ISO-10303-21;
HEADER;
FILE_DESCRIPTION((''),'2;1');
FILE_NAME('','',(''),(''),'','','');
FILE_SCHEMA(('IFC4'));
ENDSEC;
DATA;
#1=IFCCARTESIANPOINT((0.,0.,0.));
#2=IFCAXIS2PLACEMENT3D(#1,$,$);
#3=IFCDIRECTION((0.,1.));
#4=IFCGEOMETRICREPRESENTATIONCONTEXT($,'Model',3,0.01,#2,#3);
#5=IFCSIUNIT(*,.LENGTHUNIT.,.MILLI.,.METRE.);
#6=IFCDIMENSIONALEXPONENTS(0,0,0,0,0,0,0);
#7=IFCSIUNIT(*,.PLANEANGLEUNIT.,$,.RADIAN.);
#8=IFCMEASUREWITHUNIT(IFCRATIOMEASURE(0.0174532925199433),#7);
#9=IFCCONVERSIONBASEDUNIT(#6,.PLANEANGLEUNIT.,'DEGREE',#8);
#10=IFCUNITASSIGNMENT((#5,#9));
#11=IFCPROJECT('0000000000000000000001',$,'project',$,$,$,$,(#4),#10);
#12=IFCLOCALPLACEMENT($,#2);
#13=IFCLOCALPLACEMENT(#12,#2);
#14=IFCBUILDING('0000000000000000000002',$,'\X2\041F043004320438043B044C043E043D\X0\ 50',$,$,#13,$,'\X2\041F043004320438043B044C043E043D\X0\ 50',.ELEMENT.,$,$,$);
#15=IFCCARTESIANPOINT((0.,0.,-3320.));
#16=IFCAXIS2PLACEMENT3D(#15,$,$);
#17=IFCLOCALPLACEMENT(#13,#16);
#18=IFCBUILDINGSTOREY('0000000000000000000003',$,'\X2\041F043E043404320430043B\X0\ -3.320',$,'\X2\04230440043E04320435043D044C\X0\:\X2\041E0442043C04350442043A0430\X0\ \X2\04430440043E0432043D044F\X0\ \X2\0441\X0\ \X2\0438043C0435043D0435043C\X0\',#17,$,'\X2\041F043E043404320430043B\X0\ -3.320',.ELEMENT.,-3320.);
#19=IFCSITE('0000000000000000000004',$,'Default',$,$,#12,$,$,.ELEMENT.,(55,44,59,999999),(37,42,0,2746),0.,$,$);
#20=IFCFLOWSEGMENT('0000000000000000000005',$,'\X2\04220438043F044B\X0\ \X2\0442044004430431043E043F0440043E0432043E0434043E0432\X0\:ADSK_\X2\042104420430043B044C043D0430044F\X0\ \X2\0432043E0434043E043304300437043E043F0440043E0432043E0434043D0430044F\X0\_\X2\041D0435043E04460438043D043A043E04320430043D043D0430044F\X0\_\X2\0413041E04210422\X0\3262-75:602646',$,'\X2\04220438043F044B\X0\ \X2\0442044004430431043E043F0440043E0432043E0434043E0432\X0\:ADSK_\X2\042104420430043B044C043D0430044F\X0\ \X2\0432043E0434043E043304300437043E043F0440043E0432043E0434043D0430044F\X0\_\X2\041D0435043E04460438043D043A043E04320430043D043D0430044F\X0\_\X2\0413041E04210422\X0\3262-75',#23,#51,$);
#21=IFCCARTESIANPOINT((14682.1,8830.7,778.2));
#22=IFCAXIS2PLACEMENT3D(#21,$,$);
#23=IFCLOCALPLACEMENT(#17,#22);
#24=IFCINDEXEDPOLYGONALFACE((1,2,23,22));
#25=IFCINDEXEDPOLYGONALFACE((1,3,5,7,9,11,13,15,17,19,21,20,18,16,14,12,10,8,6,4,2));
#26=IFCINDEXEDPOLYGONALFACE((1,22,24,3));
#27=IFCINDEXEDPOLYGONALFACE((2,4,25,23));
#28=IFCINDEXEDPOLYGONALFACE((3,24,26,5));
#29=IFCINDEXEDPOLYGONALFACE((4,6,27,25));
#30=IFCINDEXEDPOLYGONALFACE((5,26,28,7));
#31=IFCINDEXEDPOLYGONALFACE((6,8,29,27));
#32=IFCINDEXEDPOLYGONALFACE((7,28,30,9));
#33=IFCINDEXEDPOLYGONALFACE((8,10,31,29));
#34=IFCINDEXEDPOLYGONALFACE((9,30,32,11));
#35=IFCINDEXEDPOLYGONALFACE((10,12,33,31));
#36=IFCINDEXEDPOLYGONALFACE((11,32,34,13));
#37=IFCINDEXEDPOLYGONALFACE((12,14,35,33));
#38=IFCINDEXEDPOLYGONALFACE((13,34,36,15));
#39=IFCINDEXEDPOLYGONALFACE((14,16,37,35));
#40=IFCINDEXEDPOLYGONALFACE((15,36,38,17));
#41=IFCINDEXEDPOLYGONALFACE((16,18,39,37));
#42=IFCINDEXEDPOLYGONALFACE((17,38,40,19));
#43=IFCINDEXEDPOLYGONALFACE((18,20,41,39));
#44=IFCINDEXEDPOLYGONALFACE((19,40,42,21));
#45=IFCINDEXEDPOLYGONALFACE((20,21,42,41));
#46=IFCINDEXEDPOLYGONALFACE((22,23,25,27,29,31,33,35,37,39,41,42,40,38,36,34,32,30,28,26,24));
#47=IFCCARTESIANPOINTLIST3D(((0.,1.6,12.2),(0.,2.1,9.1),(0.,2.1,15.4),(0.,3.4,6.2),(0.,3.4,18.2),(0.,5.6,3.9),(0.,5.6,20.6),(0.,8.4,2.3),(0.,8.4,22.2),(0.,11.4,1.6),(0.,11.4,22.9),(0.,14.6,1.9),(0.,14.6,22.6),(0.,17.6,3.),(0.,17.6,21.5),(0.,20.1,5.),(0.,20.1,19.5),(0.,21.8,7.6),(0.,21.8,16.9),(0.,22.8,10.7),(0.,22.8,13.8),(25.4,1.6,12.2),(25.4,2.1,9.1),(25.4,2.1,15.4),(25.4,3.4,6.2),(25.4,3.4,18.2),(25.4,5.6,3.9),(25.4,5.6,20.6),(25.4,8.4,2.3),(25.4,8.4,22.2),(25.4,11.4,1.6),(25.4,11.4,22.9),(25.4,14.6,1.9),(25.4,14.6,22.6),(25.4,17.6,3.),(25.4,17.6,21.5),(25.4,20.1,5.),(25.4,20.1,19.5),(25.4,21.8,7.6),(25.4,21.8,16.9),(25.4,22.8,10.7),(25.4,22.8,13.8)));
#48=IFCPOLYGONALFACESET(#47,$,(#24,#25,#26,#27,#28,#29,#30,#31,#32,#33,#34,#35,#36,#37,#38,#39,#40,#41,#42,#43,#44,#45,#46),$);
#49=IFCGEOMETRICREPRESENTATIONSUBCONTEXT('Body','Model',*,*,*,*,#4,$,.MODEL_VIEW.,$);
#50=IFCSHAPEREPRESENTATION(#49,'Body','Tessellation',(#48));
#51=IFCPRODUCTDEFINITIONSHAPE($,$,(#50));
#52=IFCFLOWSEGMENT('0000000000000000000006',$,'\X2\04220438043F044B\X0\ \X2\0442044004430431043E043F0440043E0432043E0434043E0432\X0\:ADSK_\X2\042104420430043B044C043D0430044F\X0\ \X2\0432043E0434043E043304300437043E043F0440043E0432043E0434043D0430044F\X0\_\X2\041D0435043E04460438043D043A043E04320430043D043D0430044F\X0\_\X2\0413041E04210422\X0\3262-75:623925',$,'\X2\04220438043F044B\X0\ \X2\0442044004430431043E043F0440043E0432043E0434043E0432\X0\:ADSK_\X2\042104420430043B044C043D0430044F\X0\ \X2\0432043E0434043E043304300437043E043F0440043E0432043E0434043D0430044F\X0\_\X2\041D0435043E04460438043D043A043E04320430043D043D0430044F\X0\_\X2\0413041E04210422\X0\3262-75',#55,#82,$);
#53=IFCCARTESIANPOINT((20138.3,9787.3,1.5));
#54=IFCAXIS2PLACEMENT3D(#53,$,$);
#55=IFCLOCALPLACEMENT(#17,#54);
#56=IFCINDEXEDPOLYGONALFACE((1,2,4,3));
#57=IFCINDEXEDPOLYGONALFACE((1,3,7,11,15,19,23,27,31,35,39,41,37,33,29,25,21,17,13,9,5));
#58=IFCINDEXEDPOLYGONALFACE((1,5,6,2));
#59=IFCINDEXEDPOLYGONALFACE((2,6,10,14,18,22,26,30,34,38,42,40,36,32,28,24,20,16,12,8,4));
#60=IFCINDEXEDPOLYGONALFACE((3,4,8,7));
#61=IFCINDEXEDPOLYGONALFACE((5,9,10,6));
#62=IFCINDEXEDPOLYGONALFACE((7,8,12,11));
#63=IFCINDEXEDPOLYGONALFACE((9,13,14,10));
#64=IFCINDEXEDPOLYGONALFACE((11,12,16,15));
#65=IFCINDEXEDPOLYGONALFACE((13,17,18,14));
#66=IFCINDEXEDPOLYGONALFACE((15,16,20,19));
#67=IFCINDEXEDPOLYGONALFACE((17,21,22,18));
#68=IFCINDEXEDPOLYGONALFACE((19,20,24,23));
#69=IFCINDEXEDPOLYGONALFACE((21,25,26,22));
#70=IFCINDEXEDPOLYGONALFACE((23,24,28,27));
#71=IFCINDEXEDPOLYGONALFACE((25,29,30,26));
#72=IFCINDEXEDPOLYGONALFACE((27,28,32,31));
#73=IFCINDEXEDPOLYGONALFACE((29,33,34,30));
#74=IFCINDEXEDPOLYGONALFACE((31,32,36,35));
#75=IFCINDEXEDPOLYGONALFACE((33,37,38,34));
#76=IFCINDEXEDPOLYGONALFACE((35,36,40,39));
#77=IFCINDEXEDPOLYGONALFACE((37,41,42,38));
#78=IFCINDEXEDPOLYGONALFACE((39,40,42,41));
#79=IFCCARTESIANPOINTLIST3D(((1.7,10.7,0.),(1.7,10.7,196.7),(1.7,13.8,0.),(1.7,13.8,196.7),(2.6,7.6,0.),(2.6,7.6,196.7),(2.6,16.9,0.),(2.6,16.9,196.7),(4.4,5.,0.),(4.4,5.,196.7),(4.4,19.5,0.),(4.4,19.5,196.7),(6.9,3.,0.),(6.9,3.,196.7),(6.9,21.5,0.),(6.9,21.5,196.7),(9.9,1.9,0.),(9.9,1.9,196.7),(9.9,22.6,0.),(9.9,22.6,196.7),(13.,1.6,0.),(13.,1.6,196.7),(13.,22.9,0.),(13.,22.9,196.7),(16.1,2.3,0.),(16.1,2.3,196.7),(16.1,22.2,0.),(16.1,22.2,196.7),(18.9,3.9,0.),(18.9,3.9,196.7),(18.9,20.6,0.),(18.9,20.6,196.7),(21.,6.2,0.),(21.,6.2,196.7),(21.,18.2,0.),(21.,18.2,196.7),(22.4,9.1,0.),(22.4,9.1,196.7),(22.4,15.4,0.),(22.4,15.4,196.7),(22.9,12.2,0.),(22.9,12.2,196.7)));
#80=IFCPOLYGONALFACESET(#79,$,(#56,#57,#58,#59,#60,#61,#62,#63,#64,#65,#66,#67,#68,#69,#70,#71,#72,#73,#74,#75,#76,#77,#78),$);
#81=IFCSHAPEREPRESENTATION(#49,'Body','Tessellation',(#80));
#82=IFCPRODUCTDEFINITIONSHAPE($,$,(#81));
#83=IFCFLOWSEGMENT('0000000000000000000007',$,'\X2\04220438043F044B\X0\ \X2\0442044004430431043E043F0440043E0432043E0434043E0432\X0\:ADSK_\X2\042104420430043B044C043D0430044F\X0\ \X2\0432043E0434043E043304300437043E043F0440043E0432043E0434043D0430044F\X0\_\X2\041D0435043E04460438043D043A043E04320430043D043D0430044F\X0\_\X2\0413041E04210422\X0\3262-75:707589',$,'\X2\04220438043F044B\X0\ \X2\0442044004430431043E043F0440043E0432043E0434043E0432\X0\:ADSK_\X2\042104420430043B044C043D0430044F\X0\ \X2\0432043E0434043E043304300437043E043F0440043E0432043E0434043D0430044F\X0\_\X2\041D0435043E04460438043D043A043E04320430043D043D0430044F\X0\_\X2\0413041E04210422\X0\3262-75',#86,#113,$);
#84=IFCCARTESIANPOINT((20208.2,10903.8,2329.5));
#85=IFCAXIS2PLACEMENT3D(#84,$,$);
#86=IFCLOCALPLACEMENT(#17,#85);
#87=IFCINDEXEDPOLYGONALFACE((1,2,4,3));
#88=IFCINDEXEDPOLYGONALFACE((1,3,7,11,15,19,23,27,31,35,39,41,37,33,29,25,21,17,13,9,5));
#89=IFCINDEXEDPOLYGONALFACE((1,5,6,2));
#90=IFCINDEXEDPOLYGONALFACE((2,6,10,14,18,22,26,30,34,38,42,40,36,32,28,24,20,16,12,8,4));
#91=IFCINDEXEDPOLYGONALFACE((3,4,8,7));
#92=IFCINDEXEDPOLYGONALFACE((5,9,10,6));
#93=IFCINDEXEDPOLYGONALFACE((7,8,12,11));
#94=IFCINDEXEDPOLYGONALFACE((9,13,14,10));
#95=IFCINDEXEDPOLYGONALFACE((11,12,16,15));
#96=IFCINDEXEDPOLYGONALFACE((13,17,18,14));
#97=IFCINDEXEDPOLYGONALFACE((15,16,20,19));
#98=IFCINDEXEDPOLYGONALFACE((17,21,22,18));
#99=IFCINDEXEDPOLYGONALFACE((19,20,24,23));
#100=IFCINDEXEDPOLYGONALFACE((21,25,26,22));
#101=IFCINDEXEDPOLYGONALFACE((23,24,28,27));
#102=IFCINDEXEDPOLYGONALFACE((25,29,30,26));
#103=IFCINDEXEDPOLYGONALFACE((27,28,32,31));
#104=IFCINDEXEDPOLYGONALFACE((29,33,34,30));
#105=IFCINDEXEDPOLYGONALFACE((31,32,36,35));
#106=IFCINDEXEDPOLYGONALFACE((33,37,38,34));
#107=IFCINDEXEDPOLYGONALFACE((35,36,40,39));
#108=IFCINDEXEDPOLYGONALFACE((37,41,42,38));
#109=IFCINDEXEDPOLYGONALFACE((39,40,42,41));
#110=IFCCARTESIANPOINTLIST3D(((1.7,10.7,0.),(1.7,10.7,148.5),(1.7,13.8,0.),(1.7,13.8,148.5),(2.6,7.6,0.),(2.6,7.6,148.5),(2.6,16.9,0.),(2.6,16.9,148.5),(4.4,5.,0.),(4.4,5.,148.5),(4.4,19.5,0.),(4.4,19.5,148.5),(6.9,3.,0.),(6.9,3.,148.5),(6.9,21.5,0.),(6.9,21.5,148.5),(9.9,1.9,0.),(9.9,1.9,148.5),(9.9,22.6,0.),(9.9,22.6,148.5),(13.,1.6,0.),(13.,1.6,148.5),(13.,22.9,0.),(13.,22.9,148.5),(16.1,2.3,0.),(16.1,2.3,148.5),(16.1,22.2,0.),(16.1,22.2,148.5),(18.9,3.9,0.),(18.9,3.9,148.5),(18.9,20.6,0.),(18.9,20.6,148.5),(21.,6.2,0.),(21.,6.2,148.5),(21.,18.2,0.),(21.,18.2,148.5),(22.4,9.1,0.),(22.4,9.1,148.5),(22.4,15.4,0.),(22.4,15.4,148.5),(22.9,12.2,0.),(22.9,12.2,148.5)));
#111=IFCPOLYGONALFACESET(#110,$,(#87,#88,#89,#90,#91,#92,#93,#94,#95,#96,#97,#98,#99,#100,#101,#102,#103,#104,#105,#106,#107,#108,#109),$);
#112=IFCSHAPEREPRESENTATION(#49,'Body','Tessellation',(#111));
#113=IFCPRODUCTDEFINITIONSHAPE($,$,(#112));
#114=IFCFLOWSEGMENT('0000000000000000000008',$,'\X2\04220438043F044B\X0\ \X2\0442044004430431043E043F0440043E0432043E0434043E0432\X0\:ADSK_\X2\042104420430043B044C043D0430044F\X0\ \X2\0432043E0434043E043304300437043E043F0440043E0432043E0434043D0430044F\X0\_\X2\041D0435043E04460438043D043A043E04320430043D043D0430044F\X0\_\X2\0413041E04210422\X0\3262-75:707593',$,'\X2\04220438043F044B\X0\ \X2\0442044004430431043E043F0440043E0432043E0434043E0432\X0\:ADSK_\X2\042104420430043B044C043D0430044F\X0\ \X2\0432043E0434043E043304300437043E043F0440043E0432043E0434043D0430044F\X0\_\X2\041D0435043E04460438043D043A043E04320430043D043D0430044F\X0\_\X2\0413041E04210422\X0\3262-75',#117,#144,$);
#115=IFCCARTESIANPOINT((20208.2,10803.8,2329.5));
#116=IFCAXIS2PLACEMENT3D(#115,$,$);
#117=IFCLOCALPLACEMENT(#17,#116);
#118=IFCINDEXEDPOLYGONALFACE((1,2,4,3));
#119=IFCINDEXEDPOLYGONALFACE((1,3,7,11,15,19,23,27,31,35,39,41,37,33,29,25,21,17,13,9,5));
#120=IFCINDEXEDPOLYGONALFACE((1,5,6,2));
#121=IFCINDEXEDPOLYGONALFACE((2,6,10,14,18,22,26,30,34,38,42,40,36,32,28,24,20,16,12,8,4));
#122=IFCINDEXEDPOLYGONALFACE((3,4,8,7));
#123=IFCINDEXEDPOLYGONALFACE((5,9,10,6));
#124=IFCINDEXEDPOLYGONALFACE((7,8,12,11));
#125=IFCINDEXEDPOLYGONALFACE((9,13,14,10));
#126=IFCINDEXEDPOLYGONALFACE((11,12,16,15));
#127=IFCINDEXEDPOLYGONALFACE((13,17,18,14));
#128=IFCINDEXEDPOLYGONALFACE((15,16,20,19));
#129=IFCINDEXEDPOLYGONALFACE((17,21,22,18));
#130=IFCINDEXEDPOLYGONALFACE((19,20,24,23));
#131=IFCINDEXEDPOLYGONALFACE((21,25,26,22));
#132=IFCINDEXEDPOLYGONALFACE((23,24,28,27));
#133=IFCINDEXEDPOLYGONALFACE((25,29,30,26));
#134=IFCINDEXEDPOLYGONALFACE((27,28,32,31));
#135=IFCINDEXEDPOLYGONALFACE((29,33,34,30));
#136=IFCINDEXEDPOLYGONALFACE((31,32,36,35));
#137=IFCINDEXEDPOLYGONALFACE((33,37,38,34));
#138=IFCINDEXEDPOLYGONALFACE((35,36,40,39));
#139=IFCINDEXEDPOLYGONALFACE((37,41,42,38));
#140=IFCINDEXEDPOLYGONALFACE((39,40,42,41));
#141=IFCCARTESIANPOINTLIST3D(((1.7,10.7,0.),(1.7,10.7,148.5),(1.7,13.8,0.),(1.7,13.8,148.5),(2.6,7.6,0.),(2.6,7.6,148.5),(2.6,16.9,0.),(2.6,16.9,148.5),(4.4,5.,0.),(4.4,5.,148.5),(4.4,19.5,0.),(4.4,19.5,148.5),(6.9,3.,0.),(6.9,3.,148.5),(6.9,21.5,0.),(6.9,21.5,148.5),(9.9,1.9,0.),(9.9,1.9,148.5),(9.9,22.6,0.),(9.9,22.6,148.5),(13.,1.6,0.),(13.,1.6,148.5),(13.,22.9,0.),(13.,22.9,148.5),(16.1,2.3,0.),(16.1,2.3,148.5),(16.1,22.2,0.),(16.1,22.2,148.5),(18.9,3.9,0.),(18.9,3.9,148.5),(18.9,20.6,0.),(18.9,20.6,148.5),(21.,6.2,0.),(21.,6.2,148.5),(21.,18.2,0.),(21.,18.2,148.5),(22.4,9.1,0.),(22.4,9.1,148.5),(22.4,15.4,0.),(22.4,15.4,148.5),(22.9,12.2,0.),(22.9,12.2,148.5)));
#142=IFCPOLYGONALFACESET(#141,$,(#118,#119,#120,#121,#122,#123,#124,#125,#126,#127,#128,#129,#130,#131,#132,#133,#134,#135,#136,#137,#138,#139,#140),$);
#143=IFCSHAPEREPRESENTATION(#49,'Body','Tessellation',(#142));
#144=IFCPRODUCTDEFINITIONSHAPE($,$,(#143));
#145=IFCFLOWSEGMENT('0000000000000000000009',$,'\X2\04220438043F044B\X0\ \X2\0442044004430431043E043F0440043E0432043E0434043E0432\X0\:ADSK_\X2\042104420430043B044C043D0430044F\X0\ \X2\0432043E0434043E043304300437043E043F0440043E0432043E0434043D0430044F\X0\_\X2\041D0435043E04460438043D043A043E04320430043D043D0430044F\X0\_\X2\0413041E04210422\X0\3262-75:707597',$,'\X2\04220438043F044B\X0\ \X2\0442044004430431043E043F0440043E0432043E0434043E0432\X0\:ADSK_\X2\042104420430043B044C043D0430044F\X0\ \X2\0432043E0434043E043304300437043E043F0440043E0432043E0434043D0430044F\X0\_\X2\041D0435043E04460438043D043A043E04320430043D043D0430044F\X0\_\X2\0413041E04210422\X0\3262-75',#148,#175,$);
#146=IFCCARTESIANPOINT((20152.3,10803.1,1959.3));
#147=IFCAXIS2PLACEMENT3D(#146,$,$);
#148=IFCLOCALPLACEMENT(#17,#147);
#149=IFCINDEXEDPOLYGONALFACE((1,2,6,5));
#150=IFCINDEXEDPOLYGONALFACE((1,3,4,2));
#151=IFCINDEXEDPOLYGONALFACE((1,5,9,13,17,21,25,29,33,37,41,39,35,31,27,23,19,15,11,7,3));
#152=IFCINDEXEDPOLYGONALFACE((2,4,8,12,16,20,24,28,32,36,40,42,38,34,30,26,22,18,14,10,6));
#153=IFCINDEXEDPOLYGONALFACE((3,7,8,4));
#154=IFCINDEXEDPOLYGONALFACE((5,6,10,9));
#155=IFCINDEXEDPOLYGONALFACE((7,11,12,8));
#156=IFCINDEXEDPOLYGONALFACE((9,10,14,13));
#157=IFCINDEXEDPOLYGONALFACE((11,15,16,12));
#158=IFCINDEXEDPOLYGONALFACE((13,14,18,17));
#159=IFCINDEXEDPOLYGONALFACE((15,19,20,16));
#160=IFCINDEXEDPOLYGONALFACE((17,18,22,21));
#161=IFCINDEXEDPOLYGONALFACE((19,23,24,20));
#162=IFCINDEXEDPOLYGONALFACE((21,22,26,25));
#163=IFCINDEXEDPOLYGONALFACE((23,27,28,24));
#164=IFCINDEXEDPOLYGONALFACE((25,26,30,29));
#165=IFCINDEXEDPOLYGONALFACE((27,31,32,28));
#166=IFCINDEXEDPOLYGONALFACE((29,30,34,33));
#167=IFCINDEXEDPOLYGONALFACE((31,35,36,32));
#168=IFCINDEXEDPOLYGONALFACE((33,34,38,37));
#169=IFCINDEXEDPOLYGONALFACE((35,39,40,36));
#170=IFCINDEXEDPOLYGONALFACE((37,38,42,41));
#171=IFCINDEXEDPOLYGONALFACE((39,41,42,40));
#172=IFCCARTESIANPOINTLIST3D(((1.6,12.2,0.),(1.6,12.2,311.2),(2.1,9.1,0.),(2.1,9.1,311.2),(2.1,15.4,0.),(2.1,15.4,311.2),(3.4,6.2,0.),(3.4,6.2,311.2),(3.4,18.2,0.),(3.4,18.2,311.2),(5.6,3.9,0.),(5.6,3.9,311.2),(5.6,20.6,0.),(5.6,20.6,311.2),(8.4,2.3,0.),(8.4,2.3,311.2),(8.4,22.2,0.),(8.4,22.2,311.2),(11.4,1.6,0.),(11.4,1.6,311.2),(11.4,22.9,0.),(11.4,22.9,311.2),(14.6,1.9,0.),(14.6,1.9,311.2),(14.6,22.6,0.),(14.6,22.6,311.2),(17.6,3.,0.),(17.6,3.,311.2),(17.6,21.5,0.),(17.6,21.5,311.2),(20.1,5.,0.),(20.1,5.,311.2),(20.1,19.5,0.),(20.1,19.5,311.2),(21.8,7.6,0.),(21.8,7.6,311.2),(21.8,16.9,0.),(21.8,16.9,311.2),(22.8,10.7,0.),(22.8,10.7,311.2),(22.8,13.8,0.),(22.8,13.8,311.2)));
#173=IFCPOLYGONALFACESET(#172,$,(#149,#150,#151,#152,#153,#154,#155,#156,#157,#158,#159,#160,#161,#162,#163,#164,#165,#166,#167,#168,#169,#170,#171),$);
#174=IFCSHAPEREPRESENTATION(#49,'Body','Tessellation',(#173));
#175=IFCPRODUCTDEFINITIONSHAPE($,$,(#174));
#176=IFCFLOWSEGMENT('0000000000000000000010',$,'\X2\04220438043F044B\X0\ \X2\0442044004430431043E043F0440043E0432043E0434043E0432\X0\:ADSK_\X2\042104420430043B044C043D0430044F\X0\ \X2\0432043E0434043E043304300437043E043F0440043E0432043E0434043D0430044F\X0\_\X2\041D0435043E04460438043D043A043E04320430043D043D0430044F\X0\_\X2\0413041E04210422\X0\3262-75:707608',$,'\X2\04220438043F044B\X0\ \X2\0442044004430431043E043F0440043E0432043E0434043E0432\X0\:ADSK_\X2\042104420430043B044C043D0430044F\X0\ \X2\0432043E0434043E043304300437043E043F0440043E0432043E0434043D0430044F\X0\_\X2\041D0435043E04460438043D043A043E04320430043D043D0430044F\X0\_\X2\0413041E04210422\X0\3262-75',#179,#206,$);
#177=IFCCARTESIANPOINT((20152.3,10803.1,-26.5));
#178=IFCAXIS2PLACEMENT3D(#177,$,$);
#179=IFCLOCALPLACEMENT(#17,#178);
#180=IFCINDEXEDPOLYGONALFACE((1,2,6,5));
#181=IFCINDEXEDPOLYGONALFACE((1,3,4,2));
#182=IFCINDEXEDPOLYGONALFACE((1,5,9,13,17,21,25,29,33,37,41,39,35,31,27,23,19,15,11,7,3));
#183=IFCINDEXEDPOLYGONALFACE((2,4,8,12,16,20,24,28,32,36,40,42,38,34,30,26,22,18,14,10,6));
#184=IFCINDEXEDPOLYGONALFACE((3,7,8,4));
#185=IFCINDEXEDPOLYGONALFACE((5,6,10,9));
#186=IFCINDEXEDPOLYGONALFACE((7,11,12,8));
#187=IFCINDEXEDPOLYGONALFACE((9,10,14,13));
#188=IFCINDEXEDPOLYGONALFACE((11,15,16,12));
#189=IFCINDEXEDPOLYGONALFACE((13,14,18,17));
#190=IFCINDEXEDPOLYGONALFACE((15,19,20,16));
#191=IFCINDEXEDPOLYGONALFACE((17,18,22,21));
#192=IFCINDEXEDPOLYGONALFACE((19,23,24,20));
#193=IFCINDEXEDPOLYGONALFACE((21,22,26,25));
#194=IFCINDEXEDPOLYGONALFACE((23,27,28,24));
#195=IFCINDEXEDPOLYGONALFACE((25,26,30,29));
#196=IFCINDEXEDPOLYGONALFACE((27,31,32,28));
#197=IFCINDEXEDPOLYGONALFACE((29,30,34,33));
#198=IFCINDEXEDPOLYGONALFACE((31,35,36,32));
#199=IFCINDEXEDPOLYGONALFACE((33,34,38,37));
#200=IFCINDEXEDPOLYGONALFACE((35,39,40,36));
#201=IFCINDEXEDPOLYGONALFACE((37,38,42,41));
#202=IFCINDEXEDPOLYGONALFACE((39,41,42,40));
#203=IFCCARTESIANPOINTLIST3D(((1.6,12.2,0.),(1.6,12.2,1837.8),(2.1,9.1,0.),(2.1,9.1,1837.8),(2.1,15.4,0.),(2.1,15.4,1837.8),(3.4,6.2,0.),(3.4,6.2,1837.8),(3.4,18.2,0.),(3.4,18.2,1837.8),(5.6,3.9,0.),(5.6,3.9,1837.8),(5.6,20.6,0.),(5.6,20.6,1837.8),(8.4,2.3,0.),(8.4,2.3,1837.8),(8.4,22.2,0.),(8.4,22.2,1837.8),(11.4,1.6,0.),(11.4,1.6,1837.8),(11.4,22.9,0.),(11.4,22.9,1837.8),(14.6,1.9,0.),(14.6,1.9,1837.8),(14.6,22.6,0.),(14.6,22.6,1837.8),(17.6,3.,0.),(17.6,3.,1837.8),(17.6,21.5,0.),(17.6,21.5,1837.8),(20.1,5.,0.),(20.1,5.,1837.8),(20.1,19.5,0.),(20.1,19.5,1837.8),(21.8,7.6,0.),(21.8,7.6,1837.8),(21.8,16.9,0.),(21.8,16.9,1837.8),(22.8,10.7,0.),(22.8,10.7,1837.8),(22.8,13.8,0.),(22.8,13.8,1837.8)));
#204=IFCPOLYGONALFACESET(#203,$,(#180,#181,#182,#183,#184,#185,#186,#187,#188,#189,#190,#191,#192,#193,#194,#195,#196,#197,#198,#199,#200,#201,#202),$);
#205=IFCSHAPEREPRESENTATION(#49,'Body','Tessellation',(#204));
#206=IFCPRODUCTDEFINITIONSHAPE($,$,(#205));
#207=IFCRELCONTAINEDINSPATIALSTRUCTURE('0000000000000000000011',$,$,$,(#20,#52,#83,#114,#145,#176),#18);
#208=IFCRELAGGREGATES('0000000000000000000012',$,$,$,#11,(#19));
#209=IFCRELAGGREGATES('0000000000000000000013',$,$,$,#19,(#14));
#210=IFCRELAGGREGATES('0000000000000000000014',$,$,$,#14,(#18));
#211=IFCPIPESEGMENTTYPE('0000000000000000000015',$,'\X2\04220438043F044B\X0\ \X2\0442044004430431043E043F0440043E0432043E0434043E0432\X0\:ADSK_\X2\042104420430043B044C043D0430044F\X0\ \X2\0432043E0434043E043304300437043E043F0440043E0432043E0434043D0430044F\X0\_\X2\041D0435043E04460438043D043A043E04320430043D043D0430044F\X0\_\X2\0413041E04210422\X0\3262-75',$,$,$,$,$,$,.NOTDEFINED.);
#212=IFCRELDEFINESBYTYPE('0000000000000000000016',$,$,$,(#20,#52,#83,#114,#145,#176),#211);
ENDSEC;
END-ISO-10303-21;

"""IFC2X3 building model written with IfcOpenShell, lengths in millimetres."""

from ifc_helpers import new_model, entity, si_unit, converted_unit, direction, frame, frame_2d, origin, origin_2d_with_axis, place, context, subcontext, project, spatial, circle, extrude, type_object, element, save


model = new_model("IFC2X3")

# Units and contexts
model_context = context("Model", 3, precision=0.01, world=origin(), true_north=direction((0.0, 1.0)))
body_context = subcontext(model_context, "Body", "Model", "MODEL_VIEW")
ifc_project = project(units=[si_unit("LENGTHUNIT", "METRE", prefix="MILLI"), converted_unit("PLANEANGLEUNIT", "DEGREE", entity("IfcRatioMeasure", 0.0174532925199433), si_unit("PLANEANGLEUNIT", "RADIAN"), dimensions=[0, 0, 0, 0, 0, 0, 0])], contexts=[model_context])

# Site, building, storey
site_placement = place(None, origin())
site = spatial("IfcSite", under=ifc_project, at=site_placement, Name="Default", CompositionType="ELEMENT", RefLatitude=(55, 44, 59, 999999), RefLongitude=(37, 42, 0, 2746), RefElevation=0.0)
building_placement = place(site_placement, origin())
building = spatial("IfcBuilding", under=site, at=building_placement, Name="Павильон 50", LongName="Павильон 50", CompositionType="ELEMENT")
storey_placement = place(building_placement, frame((0.0, 0.0, -3320.0)))
storey = spatial("IfcBuildingStorey", under=building, at=storey_placement, Name="Подвал -3.320", ObjectType="Уровень:Отметка уровня с именем", LongName="Подвал -3.320", CompositionType="ELEMENT", Elevation=-3320.0)

# Flow segments
pipe_segment_type = type_object("IfcPipeSegmentType", Name="Типы трубопроводов:ADSK_Стальная водогазопроводная_Неоцинкованная_ГОСТ3262-75", PredefinedType="NOTDEFINED")
flow_segment_1_placement = place(storey_placement, frame((14682.1, 8830.7, 778.2)))
element("IfcFlowSegment", 1, at=flow_segment_1_placement, inside=storey, type_object=pipe_segment_type, Name="Типы трубопроводов:ADSK_Стальная водогазопроводная_Неоцинкованная_ГОСТ3262-75:602646", ObjectType="Типы трубопроводов:ADSK_Стальная водогазопроводная_Неоцинкованная_ГОСТ3262-75", context=body_context, shape_type="SweptSolid", body=[
    extrude(circle(Radius=10.7, at=origin_2d_with_axis()), frame((0.0, 12.2, 12.2), z_axis=(1.0, 0.0, 0.0), x_axis=(0.0, -1.0, 0.0)), (0.0, 0.0, 1.0), 25.4),
])
flow_segment_2_placement = place(storey_placement, frame((20138.3, 9787.3, 1.5)))
element("IfcFlowSegment", 2, at=flow_segment_2_placement, inside=storey, type_object=pipe_segment_type, Name="Типы трубопроводов:ADSK_Стальная водогазопроводная_Неоцинкованная_ГОСТ3262-75:623925", ObjectType="Типы трубопроводов:ADSK_Стальная водогазопроводная_Неоцинкованная_ГОСТ3262-75", context=body_context, shape_type="SweptSolid", body=[
    extrude(circle(Radius=10.7, at=origin_2d_with_axis()), frame((12.2, 12.2, 0.0)), (0.0, 0.0, 1.0), 196.7),
])
flow_segment_3_placement = place(storey_placement, frame((20208.2, 10903.8, 2329.5)))
element("IfcFlowSegment", 3, at=flow_segment_3_placement, inside=storey, type_object=pipe_segment_type, Name="Типы трубопроводов:ADSK_Стальная водогазопроводная_Неоцинкованная_ГОСТ3262-75:707589", ObjectType="Типы трубопроводов:ADSK_Стальная водогазопроводная_Неоцинкованная_ГОСТ3262-75", context=body_context, shape_type="SweptSolid", body=[
    extrude(circle(Radius=10.7, at=frame_2d((0.0, 0.0), x_axis=(1.0, 0.0))), frame((12.2, 12.2, 0.0)), (0.0, 0.0, 1.0), 148.5),
])
flow_segment_4_placement = place(storey_placement, frame((20208.2, 10803.8, 2329.5)))
element("IfcFlowSegment", 4, at=flow_segment_4_placement, inside=storey, type_object=pipe_segment_type, Name="Типы трубопроводов:ADSK_Стальная водогазопроводная_Неоцинкованная_ГОСТ3262-75:707593", ObjectType="Типы трубопроводов:ADSK_Стальная водогазопроводная_Неоцинкованная_ГОСТ3262-75", context=body_context, shape_type="SweptSolid", body=[
    extrude(circle(Radius=10.7, at=origin_2d_with_axis()), frame((12.2, 12.2, 0.0)), (0.0, 0.0, 1.0), 148.5),
])
flow_segment_5_placement = place(storey_placement, frame((20152.3, 10803.1, 1959.3)))
element("IfcFlowSegment", 5, at=flow_segment_5_placement, inside=storey, type_object=pipe_segment_type, Name="Типы трубопроводов:ADSK_Стальная водогазопроводная_Неоцинкованная_ГОСТ3262-75:707597", ObjectType="Типы трубопроводов:ADSK_Стальная водогазопроводная_Неоцинкованная_ГОСТ3262-75", context=body_context, shape_type="SweptSolid", body=[
    extrude(circle(Radius=10.7, at=frame_2d((0.0, 0.0), x_axis=(1.0, 0.0))), frame((12.2, 12.2, 0.0), z_axis=(0.0, 0.0, 1.0), x_axis=(-1.0, 0.0, 0.0)), (0.0, 0.0, 1.0), 311.2),
])
flow_segment_6_placement = place(storey_placement, frame((20152.3, 10803.1, -26.5)))
element("IfcFlowSegment", 6, at=flow_segment_6_placement, inside=storey, type_object=pipe_segment_type, Name="Типы трубопроводов:ADSK_Стальная водогазопроводная_Неоцинкованная_ГОСТ3262-75:707608", ObjectType="Типы трубопроводов:ADSK_Стальная водогазопроводная_Неоцинкованная_ГОСТ3262-75", context=body_context, shape_type="SweptSolid", body=[
    extrude(circle(Radius=10.7, at=origin_2d_with_axis()), frame((12.2, 12.2, 0.0), z_axis=(0.0, 0.0, 1.0), x_axis=(-1.0, 0.0, 0.0)), (0.0, 0.0, 1.0), 1837.8),
])

save(model, "model.ifc")
